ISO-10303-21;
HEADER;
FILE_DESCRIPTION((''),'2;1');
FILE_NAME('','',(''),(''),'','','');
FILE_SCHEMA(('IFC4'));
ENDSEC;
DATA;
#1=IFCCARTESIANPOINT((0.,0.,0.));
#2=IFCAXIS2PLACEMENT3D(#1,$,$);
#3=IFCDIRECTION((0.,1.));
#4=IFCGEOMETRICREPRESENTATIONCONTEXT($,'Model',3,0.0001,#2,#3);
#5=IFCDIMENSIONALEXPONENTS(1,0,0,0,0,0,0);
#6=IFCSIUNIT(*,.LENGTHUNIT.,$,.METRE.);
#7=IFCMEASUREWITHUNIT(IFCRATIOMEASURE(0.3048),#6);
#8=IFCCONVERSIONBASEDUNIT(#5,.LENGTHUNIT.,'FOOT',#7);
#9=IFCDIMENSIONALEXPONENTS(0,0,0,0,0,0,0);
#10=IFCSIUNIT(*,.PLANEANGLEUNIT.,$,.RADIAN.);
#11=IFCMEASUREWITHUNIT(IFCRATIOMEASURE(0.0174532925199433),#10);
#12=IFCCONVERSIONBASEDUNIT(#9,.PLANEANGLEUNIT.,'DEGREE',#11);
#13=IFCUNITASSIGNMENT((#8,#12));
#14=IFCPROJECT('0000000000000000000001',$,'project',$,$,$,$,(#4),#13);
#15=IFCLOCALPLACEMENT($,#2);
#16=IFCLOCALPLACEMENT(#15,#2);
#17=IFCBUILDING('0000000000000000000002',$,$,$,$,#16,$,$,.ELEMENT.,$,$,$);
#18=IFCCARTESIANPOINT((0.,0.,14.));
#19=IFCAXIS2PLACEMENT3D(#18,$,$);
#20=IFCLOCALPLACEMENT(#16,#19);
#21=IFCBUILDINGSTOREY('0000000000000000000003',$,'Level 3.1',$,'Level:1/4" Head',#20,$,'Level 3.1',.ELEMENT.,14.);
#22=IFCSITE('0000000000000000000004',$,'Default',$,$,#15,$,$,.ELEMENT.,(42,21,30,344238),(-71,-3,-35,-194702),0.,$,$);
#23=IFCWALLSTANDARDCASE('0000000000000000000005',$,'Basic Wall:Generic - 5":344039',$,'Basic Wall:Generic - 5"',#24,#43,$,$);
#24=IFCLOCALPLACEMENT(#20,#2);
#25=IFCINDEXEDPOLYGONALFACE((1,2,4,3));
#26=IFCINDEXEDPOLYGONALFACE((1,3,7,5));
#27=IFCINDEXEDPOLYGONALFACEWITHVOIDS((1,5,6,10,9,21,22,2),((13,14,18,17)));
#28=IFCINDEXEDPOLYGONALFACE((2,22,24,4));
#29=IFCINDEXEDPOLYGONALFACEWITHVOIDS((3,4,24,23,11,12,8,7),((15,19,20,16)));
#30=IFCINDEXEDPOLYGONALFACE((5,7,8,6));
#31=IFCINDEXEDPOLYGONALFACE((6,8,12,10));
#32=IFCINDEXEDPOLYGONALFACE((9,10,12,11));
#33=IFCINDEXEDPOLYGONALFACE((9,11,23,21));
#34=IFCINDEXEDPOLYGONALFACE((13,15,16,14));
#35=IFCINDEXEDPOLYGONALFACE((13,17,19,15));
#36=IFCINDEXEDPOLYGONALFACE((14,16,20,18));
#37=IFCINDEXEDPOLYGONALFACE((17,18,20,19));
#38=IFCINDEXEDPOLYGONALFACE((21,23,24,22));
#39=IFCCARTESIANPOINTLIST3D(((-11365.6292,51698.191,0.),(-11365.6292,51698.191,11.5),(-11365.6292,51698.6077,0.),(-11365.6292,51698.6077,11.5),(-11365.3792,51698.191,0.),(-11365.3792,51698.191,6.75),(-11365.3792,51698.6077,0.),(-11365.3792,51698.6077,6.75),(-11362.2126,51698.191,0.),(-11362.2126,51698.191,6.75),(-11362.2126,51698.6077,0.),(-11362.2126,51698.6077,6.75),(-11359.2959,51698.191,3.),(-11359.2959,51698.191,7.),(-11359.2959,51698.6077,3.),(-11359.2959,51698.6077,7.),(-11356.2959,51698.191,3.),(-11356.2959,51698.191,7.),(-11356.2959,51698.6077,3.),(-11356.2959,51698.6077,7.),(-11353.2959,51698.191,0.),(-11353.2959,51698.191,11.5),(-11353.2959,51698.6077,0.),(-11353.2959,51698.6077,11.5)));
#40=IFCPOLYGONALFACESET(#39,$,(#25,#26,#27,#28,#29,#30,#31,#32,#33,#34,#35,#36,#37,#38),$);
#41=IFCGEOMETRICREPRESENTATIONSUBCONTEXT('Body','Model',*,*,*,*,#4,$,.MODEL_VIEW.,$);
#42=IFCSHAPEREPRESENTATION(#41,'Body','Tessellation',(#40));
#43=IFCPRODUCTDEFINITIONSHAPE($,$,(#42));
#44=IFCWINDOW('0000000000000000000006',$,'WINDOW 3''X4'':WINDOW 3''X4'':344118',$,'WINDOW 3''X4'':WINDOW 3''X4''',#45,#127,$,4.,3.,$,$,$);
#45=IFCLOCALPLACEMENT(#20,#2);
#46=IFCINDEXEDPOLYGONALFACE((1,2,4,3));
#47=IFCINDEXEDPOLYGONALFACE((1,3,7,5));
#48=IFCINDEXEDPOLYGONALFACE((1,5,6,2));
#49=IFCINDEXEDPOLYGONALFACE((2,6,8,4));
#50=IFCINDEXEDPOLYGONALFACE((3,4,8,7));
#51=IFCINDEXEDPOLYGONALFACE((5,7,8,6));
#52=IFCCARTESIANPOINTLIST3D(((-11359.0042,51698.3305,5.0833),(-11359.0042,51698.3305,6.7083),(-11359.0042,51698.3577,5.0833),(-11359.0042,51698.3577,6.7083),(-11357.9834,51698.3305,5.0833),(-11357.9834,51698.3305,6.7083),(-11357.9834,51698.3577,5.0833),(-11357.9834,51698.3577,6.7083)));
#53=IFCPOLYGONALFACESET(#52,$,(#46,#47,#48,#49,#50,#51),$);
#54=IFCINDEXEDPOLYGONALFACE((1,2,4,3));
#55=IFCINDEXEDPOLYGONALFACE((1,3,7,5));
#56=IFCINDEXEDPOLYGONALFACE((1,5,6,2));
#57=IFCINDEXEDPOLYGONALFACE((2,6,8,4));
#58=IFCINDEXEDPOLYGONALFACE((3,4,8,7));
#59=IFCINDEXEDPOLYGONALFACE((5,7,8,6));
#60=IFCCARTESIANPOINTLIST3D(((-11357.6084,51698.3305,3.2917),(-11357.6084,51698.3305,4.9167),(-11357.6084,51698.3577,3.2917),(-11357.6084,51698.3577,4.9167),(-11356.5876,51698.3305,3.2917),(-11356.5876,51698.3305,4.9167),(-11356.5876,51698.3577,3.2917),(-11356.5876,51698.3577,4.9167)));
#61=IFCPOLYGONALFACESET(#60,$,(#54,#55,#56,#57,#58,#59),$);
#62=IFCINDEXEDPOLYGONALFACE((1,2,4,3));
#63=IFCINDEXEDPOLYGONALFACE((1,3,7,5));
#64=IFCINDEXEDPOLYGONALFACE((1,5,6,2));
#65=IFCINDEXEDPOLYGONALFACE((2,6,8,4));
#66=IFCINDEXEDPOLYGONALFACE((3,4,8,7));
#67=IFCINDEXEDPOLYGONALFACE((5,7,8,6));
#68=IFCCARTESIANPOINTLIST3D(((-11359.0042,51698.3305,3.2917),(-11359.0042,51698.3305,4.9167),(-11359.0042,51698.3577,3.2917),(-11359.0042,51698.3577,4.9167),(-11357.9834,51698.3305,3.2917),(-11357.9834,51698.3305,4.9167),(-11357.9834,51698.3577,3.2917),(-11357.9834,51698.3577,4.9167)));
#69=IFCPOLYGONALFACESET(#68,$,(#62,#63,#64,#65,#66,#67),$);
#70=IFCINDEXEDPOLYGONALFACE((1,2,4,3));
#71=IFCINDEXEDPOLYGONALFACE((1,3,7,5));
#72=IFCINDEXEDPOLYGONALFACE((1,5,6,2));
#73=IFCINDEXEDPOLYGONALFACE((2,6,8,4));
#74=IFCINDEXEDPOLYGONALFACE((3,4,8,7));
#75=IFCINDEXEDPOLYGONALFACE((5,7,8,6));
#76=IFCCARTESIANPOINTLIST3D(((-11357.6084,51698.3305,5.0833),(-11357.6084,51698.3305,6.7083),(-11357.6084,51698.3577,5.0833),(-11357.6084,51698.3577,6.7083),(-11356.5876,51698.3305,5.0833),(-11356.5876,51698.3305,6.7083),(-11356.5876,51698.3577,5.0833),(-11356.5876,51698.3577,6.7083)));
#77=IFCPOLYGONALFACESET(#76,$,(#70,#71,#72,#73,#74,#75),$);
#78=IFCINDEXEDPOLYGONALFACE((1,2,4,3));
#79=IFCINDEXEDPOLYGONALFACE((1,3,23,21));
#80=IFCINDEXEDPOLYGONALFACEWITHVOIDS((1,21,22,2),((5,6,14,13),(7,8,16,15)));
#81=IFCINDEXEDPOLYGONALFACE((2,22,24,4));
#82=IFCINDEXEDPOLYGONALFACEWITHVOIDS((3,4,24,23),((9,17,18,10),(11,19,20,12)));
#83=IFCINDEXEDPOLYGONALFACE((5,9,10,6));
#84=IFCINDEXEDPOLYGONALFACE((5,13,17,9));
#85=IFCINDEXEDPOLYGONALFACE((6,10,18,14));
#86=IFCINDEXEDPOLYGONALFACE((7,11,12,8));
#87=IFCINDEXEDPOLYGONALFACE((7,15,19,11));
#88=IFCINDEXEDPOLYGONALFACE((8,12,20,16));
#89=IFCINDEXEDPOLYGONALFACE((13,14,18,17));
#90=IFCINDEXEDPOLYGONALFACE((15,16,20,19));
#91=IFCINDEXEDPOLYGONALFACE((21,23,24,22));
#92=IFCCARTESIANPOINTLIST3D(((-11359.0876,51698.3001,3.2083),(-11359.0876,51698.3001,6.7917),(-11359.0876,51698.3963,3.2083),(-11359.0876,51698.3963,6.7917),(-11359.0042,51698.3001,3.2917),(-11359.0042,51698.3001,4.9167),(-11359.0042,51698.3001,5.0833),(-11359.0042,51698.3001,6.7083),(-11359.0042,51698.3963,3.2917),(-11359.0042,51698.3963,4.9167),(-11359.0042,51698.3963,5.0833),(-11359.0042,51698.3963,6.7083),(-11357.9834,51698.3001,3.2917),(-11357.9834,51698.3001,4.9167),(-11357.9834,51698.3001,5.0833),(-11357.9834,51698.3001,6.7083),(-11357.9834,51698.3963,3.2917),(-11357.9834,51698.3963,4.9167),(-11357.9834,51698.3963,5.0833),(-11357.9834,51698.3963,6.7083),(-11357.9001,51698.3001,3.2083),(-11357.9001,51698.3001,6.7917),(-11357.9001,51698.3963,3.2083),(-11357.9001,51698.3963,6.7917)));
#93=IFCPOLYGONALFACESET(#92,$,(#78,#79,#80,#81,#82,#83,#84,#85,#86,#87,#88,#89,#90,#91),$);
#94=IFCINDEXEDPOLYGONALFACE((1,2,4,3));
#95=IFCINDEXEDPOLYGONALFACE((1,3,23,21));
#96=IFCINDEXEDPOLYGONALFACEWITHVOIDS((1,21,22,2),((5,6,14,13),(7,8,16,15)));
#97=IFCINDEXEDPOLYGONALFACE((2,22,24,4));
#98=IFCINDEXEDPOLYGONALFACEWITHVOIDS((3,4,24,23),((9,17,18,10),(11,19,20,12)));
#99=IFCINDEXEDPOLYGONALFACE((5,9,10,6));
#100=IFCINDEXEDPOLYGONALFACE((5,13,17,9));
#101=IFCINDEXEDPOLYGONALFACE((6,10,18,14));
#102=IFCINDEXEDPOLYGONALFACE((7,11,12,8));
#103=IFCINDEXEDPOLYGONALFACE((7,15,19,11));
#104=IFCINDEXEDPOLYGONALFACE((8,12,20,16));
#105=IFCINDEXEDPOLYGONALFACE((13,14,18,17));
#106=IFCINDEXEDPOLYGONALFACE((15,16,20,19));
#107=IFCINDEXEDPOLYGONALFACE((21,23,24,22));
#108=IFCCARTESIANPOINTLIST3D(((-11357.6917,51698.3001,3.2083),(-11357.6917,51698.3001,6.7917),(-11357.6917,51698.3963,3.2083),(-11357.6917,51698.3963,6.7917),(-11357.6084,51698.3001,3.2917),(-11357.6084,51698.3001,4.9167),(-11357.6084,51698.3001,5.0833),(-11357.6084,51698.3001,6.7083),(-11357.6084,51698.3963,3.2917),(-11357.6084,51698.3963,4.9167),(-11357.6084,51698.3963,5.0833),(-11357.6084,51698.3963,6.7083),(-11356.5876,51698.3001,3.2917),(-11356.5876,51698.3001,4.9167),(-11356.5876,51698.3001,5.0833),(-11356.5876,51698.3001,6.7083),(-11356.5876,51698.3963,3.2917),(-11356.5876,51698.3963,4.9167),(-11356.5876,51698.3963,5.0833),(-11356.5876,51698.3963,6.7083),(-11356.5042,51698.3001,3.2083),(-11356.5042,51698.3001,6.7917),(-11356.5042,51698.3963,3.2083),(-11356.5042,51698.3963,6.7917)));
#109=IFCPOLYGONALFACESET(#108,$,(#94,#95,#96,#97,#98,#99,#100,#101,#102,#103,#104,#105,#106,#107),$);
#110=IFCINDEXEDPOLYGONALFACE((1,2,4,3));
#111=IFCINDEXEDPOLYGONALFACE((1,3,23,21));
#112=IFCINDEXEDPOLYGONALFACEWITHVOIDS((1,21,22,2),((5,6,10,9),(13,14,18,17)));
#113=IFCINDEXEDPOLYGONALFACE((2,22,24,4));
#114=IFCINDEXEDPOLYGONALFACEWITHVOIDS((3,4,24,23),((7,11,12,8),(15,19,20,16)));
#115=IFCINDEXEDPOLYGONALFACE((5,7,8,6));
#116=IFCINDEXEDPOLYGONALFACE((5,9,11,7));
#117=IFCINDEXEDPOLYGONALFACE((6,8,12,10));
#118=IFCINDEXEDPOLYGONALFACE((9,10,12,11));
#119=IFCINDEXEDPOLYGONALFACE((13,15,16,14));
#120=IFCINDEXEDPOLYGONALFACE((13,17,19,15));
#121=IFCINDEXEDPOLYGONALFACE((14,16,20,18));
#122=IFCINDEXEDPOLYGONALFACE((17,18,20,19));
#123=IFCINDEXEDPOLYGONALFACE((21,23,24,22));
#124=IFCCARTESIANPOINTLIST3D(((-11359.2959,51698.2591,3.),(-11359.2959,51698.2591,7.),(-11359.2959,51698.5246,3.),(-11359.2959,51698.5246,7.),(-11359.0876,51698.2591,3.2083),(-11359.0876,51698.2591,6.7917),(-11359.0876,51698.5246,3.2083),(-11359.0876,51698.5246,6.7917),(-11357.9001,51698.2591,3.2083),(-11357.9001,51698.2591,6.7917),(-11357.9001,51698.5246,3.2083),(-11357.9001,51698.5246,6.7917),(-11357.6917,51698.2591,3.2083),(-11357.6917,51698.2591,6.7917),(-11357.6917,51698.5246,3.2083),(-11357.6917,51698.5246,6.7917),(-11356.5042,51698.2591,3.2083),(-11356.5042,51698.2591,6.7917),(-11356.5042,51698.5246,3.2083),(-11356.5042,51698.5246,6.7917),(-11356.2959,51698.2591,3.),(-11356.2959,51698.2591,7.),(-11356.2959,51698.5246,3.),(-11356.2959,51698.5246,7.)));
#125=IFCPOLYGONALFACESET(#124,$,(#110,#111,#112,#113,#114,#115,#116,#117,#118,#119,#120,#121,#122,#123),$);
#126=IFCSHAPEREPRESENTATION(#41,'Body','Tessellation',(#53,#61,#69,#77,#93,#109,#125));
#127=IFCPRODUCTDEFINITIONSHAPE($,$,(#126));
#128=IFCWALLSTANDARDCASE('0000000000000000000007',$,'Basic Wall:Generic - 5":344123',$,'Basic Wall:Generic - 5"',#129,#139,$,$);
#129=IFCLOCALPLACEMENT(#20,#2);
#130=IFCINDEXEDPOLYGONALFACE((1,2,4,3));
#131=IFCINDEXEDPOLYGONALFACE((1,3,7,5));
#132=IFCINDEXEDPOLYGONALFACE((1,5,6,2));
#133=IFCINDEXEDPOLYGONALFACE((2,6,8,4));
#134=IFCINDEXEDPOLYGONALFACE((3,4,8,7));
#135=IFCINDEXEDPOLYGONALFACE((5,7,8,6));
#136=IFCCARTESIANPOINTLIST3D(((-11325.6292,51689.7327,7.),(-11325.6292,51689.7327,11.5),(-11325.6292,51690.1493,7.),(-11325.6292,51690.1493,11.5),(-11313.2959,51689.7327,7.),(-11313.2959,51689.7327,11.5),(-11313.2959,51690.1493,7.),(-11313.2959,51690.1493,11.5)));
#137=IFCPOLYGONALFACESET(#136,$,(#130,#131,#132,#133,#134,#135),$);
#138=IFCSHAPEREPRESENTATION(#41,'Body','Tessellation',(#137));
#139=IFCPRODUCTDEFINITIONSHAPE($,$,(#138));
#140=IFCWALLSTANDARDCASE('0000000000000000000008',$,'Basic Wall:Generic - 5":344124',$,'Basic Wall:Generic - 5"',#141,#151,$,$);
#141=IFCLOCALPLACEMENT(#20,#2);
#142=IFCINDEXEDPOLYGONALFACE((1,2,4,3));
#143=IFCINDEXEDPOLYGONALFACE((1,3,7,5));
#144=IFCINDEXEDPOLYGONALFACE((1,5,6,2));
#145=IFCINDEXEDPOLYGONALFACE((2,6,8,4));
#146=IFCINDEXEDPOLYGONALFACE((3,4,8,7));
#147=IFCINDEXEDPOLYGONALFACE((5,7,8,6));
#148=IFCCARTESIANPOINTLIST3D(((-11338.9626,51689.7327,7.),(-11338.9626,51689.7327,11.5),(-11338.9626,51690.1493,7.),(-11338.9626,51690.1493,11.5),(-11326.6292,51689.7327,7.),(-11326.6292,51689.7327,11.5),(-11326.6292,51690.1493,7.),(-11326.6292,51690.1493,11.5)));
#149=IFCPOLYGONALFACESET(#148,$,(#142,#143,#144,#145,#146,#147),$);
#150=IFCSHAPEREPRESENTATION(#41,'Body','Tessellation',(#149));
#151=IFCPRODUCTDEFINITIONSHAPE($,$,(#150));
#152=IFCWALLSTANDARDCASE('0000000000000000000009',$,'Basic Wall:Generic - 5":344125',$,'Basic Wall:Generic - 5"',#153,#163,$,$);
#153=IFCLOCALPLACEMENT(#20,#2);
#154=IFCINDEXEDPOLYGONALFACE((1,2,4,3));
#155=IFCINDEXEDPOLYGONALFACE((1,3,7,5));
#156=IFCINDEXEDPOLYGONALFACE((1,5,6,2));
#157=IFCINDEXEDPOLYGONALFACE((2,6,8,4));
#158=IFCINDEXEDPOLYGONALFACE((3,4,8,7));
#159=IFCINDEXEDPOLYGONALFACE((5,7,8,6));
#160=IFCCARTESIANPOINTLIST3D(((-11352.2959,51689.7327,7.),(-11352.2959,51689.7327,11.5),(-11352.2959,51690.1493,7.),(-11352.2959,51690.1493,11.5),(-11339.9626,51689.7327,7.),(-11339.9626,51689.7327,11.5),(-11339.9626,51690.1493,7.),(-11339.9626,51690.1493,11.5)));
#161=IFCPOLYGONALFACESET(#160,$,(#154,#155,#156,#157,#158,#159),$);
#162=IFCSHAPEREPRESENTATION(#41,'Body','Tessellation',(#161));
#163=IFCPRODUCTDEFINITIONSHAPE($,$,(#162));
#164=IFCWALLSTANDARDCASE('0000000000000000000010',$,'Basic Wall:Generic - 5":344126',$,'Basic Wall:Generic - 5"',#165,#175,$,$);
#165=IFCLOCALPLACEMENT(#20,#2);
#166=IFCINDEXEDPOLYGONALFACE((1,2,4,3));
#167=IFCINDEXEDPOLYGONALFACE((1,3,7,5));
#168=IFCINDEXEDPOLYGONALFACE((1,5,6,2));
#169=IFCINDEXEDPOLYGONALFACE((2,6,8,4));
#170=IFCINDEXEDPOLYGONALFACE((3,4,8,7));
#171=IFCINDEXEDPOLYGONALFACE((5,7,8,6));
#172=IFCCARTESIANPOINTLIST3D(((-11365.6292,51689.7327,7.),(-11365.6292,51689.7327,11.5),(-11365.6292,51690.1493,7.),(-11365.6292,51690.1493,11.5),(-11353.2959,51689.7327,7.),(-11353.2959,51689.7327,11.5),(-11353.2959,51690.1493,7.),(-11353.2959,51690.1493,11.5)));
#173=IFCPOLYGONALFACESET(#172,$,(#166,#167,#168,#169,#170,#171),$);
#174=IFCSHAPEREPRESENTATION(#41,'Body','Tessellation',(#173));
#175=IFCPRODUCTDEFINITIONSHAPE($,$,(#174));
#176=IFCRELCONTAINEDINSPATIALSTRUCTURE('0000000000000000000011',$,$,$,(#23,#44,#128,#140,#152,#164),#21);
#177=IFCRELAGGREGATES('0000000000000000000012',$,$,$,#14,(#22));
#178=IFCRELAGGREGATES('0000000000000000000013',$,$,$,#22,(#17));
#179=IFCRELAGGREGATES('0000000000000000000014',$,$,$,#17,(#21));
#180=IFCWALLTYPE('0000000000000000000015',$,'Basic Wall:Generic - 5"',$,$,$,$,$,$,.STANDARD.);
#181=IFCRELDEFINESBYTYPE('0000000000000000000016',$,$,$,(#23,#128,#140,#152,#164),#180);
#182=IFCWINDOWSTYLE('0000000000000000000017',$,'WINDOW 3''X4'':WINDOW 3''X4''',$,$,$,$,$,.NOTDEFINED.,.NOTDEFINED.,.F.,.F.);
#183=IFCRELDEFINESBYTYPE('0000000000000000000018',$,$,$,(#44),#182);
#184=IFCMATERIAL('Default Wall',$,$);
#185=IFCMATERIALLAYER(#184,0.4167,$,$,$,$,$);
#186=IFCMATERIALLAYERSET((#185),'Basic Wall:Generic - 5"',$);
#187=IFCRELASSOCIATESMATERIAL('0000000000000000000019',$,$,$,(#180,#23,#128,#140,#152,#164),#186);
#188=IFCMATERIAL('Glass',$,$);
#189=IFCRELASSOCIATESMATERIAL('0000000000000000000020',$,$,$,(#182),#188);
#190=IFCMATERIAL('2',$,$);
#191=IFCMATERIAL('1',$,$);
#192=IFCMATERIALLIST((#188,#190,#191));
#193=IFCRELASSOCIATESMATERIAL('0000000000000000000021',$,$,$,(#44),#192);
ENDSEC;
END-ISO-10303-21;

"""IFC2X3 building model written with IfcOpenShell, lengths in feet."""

from ifc_helpers import new_model, entity, si_unit, converted_unit, direction, frame, frame_2d, origin, origin_2d_with_axis, place, context, subcontext, project, spatial, polyline, rectangle, outline, extrude, source, transform, mapped, material, material_list, layer, layer_set, layer_usage, type_object, type_shapes, element, fill, save


model = new_model("IFC2X3")

# Units and contexts
model_context = context("Model", 3, precision=0.0001, world=origin(), true_north=direction((0.0, 1.0)))
body_context = subcontext(model_context, "Body", "Model", "MODEL_VIEW")
ifc_project = project(units=[converted_unit("LENGTHUNIT", "FOOT", entity("IfcRatioMeasure", 0.3048), si_unit("LENGTHUNIT", "METRE"), dimensions=[1, 0, 0, 0, 0, 0, 0]), converted_unit("PLANEANGLEUNIT", "DEGREE", entity("IfcRatioMeasure", 0.0174532925199433), si_unit("PLANEANGLEUNIT", "RADIAN"), dimensions=[0, 0, 0, 0, 0, 0, 0])], contexts=[model_context])

# Site, building, storey
site_placement = place(None, origin())
site = spatial("IfcSite", under=ifc_project, at=site_placement, Name="Default", CompositionType="ELEMENT", RefLatitude=(42, 21, 30, 344238), RefLongitude=(-71, -3, -35, -194702), RefElevation=0.0)
building_placement = place(site_placement, origin())
building = spatial("IfcBuilding", under=site, at=building_placement, CompositionType="ELEMENT")
storey_placement = place(building_placement, frame((0.0, 0.0, 14.0)))
storey = spatial("IfcBuildingStorey", under=building, at=storey_placement, Name="Level 3.1", ObjectType="Level:1/4\" Head", LongName="Level 3.1", CompositionType="ELEMENT", Elevation=14.0)

# Wall, openings, window
ifc_material_1 = material(Name="Default Wall")
ifc_layer = layer(ifc_material_1, 0.4167)
ifc_layer_set = layer_set([ifc_layer], Name="Basic Wall:Generic - 5\"")
ifc_layer_usage_1 = layer_usage(ifc_layer_set, "AXIS2", "NEGATIVE", 0.2083)
wall_type = type_object("IfcWallType", Name="Basic Wall:Generic - 5\"", PredefinedType="STANDARD", material=ifc_layer_set)
wall_1_placement = place(storey_placement, frame((-11365.6292, 51698.3993, 0.0)))
wall_1 = element("IfcWallStandardCase", 1, at=wall_1_placement, inside=storey, type_object=wall_type, material=ifc_layer_usage_1, Name="Basic Wall:Generic - 5\":344039", ObjectType="Basic Wall:Generic - 5\"", context=body_context, shape_type="SweptSolid", body=[
    extrude(rectangle(XDim=12.3333, YDim=0.4167, at=frame_2d((6.1667, 0.0), x_axis=(-1.0, 0.0))), origin(), (0.0, 0.0, 1.0), 11.5),
])
opening_1_placement = place(wall_1_placement, frame((0.25, -0.2083, 0.0)))
element("IfcOpeningElement", 2, at=opening_1_placement, cuts=wall_1, ObjectType="Opening", context=body_context, shape_type="SweptSolid", body=[
    extrude(rectangle(XDim=6.75, YDim=3.1667, at=frame_2d((3.375, 1.5833), x_axis=(1.0, 0.0))), frame((0.0, 0.0, 0.0), z_axis=(0.0, 1.0, 0.0), x_axis=(0.0, 0.0, 1.0)), (0.0, 0.0, 1.0), 0.4167),
])
opening_2_placement = place(wall_1_placement, frame((9.3333, 0.2083, 3.0)))
opening_2 = element("IfcOpeningElement", 3, at=opening_2_placement, cuts=wall_1, ObjectType="Opening", context=body_context, shape_type="SweptSolid", body=[
    extrude(rectangle(XDim=4.0, YDim=3.0, at=frame_2d((2.0, 1.5), x_axis=(-1.0, 0.0))), frame((0.0, 0.0, 0.0), z_axis=(0.0, -1.0, 0.0), x_axis=(0.0, 0.0, 1.0)), (0.0, 0.0, 1.0), 0.4167),
])
ifc_material_2 = material(Name="Glass")
ifc_material_3 = material(Name="2")
ifc_material_4 = material(Name="1")
ifc_material_list = material_list([ifc_material_2, ifc_material_3, ifc_material_4])
window_style = type_object("IfcWindowStyle", Name="WINDOW 3'X4':WINDOW 3'X4'", ConstructionType="NOTDEFINED", OperationType="NOTDEFINED", ParameterTakesPrecedence=False, Sizeable=False, material=ifc_material_2)
shared_shape = source(origin(), body_context, "Body", "SweptSolid", [
    extrude(rectangle(XDim=0.0272, YDim=1.0208, at=origin_2d_with_axis()), frame((2.1979, 0.2636, 2.0833), z_axis=(0.0, 0.0, 1.0), x_axis=(0.0, 1.0, 0.0)), (0.0, 0.0, 1.0), 1.625),
    extrude(rectangle(XDim=0.0272, YDim=1.0208, at=origin_2d_with_axis()), frame((0.8021, 0.2636, 0.2917), z_axis=(0.0, 0.0, 1.0), x_axis=(0.0, 1.0, 0.0)), (0.0, 0.0, 1.0), 1.625),
    extrude(rectangle(XDim=0.0272, YDim=1.0208, at=origin_2d_with_axis()), frame((2.1979, 0.2636, 0.2917), z_axis=(0.0, 0.0, 1.0), x_axis=(0.0, 1.0, 0.0)), (0.0, 0.0, 1.0), 1.625),
    extrude(rectangle(XDim=0.0272, YDim=1.0208, at=origin_2d_with_axis()), frame((0.8021, 0.2636, 2.0833), z_axis=(0.0, 0.0, 1.0), x_axis=(0.0, 1.0, 0.0)), (0.0, 0.0, 1.0), 1.625),
    extrude(outline(polyline([(-0.5938, -1.7917), (0.5938, -1.7917), (0.5938, 1.7917), (-0.5938, 1.7917), (-0.5938, -1.7917)]), holes=[polyline([(-0.5104, -0.0833), (0.5104, -0.0833), (0.5104, -1.7083), (-0.5104, -1.7083), (-0.5104, -0.0833)]), polyline([(-0.5104, 1.7083), (0.5104, 1.7083), (0.5104, 0.0833), (-0.5104, 0.0833), (-0.5104, 1.7083)])]), frame((2.1979, 0.2114, 2.0), z_axis=(0.0, 1.0, 0.0), x_axis=(-1.0, 0.0, 0.0)), (0.0, 0.0, 1.0), 0.0962),
    extrude(outline(polyline([(-1.7917, -0.5937), (1.7917, -0.5937), (1.7917, 0.5937), (-1.7917, 0.5937), (-1.7917, -0.5937)]), holes=[polyline([(0.0833, -0.5104), (0.0833, 0.5104), (1.7083, 0.5104), (1.7083, -0.5104), (0.0833, -0.5104)]), polyline([(-1.7083, -0.5104), (-1.7083, 0.5104), (-0.0833, 0.5104), (-0.0833, -0.5104), (-1.7083, -0.5104)])]), frame((0.8021, 0.2114, 2.0), z_axis=(0.0, 1.0, 0.0), x_axis=(0.0, 0.0, -1.0)), (0.0, 0.0, 1.0), 0.0962),
    extrude(outline(polyline([(-1.5, -2.0), (1.5, -2.0), (1.5, 2.0), (-1.5, 2.0), (-1.5, -2.0)]), holes=[polyline([(-0.1042, 1.7917), (-0.1042, -1.7917), (-1.2917, -1.7917), (-1.2917, 1.7917), (-0.1042, 1.7917)]), polyline([(0.1042, -1.7917), (0.1042, 1.7917), (1.2917, 1.7917), (1.2917, -1.7917), (0.1042, -1.7917)])]), frame((1.5, 0.0831, 2.0), z_axis=(0.0, 1.0, 0.0), x_axis=(1.0, 0.0, 0.0)), (0.0, 0.0, 1.0), 0.2655),
])
type_shapes(window_style, [shared_shape])
window_placement = place(opening_2_placement, frame((0.0, 0.0, 0.0), z_axis=(0.0, 0.0, 1.0), x_axis=(-1.0, 0.0, 0.0)))
window = element("IfcWindow", 4, at=window_placement, inside=storey, type_object=window_style, material=ifc_material_list, Name="WINDOW 3'X4':WINDOW 3'X4':344118", ObjectType="WINDOW 3'X4':WINDOW 3'X4'", OverallHeight=4.0, OverallWidth=3.0, context=body_context, shape_type="MappedRepresentation", body=[
    mapped(shared_shape, transform((0.0, 0.0, 0.0), scale=1.0)),
])
fill(opening_2, window)

# Walls
ifc_layer_usage_2 = layer_usage(ifc_layer_set, "AXIS2", "NEGATIVE", 0.2083)
wall_2_placement = place(storey_placement, frame((-11313.2959, 51689.941, 7.0), z_axis=(0.0, 0.0, 1.0), x_axis=(-1.0, 0.0, 0.0)))
element("IfcWallStandardCase", 5, at=wall_2_placement, inside=storey, type_object=wall_type, material=ifc_layer_usage_2, Name="Basic Wall:Generic - 5\":344123", ObjectType="Basic Wall:Generic - 5\"", context=body_context, shape_type="SweptSolid", body=[
    extrude(rectangle(XDim=12.3333, YDim=0.4167, at=frame_2d((6.1667, 0.0), x_axis=(-1.0, 0.0))), origin(), (0.0, 0.0, 1.0), 4.5),
])
ifc_layer_usage_3 = layer_usage(ifc_layer_set, "AXIS2", "NEGATIVE", 0.2083)
wall_3_placement = place(storey_placement, frame((-11326.6292, 51689.941, 7.0), z_axis=(0.0, 0.0, 1.0), x_axis=(-1.0, 0.0, 0.0)))
element("IfcWallStandardCase", 6, at=wall_3_placement, inside=storey, type_object=wall_type, material=ifc_layer_usage_3, Name="Basic Wall:Generic - 5\":344124", ObjectType="Basic Wall:Generic - 5\"", context=body_context, shape_type="SweptSolid", body=[
    extrude(rectangle(XDim=12.3333, YDim=0.4167, at=frame_2d((6.1667, 0.0), x_axis=(-1.0, 0.0))), origin(), (0.0, 0.0, 1.0), 4.5),
])
ifc_layer_usage_4 = layer_usage(ifc_layer_set, "AXIS2", "NEGATIVE", 0.2083)
wall_4_placement = place(storey_placement, frame((-11339.9626, 51689.941, 7.0), z_axis=(0.0, 0.0, 1.0), x_axis=(-1.0, 0.0, 0.0)))
element("IfcWallStandardCase", 7, at=wall_4_placement, inside=storey, type_object=wall_type, material=ifc_layer_usage_4, Name="Basic Wall:Generic - 5\":344125", ObjectType="Basic Wall:Generic - 5\"", context=body_context, shape_type="SweptSolid", body=[
    extrude(rectangle(XDim=12.3333, YDim=0.4167, at=frame_2d((6.1667, 0.0), x_axis=(-1.0, 0.0))), origin(), (0.0, 0.0, 1.0), 4.5),
])
ifc_layer_usage_5 = layer_usage(ifc_layer_set, "AXIS2", "NEGATIVE", 0.2083)
wall_5_placement = place(storey_placement, frame((-11353.2959, 51689.941, 7.0), z_axis=(0.0, 0.0, 1.0), x_axis=(-1.0, 0.0, 0.0)))
element("IfcWallStandardCase", 8, at=wall_5_placement, inside=storey, type_object=wall_type, material=ifc_layer_usage_5, Name="Basic Wall:Generic - 5\":344126", ObjectType="Basic Wall:Generic - 5\"", context=body_context, shape_type="SweptSolid", body=[
    extrude(rectangle(XDim=12.3333, YDim=0.4167, at=frame_2d((6.1667, 0.0), x_axis=(-1.0, 0.0))), origin(), (0.0, 0.0, 1.0), 4.5),
])

save(model, "model.ifc")
